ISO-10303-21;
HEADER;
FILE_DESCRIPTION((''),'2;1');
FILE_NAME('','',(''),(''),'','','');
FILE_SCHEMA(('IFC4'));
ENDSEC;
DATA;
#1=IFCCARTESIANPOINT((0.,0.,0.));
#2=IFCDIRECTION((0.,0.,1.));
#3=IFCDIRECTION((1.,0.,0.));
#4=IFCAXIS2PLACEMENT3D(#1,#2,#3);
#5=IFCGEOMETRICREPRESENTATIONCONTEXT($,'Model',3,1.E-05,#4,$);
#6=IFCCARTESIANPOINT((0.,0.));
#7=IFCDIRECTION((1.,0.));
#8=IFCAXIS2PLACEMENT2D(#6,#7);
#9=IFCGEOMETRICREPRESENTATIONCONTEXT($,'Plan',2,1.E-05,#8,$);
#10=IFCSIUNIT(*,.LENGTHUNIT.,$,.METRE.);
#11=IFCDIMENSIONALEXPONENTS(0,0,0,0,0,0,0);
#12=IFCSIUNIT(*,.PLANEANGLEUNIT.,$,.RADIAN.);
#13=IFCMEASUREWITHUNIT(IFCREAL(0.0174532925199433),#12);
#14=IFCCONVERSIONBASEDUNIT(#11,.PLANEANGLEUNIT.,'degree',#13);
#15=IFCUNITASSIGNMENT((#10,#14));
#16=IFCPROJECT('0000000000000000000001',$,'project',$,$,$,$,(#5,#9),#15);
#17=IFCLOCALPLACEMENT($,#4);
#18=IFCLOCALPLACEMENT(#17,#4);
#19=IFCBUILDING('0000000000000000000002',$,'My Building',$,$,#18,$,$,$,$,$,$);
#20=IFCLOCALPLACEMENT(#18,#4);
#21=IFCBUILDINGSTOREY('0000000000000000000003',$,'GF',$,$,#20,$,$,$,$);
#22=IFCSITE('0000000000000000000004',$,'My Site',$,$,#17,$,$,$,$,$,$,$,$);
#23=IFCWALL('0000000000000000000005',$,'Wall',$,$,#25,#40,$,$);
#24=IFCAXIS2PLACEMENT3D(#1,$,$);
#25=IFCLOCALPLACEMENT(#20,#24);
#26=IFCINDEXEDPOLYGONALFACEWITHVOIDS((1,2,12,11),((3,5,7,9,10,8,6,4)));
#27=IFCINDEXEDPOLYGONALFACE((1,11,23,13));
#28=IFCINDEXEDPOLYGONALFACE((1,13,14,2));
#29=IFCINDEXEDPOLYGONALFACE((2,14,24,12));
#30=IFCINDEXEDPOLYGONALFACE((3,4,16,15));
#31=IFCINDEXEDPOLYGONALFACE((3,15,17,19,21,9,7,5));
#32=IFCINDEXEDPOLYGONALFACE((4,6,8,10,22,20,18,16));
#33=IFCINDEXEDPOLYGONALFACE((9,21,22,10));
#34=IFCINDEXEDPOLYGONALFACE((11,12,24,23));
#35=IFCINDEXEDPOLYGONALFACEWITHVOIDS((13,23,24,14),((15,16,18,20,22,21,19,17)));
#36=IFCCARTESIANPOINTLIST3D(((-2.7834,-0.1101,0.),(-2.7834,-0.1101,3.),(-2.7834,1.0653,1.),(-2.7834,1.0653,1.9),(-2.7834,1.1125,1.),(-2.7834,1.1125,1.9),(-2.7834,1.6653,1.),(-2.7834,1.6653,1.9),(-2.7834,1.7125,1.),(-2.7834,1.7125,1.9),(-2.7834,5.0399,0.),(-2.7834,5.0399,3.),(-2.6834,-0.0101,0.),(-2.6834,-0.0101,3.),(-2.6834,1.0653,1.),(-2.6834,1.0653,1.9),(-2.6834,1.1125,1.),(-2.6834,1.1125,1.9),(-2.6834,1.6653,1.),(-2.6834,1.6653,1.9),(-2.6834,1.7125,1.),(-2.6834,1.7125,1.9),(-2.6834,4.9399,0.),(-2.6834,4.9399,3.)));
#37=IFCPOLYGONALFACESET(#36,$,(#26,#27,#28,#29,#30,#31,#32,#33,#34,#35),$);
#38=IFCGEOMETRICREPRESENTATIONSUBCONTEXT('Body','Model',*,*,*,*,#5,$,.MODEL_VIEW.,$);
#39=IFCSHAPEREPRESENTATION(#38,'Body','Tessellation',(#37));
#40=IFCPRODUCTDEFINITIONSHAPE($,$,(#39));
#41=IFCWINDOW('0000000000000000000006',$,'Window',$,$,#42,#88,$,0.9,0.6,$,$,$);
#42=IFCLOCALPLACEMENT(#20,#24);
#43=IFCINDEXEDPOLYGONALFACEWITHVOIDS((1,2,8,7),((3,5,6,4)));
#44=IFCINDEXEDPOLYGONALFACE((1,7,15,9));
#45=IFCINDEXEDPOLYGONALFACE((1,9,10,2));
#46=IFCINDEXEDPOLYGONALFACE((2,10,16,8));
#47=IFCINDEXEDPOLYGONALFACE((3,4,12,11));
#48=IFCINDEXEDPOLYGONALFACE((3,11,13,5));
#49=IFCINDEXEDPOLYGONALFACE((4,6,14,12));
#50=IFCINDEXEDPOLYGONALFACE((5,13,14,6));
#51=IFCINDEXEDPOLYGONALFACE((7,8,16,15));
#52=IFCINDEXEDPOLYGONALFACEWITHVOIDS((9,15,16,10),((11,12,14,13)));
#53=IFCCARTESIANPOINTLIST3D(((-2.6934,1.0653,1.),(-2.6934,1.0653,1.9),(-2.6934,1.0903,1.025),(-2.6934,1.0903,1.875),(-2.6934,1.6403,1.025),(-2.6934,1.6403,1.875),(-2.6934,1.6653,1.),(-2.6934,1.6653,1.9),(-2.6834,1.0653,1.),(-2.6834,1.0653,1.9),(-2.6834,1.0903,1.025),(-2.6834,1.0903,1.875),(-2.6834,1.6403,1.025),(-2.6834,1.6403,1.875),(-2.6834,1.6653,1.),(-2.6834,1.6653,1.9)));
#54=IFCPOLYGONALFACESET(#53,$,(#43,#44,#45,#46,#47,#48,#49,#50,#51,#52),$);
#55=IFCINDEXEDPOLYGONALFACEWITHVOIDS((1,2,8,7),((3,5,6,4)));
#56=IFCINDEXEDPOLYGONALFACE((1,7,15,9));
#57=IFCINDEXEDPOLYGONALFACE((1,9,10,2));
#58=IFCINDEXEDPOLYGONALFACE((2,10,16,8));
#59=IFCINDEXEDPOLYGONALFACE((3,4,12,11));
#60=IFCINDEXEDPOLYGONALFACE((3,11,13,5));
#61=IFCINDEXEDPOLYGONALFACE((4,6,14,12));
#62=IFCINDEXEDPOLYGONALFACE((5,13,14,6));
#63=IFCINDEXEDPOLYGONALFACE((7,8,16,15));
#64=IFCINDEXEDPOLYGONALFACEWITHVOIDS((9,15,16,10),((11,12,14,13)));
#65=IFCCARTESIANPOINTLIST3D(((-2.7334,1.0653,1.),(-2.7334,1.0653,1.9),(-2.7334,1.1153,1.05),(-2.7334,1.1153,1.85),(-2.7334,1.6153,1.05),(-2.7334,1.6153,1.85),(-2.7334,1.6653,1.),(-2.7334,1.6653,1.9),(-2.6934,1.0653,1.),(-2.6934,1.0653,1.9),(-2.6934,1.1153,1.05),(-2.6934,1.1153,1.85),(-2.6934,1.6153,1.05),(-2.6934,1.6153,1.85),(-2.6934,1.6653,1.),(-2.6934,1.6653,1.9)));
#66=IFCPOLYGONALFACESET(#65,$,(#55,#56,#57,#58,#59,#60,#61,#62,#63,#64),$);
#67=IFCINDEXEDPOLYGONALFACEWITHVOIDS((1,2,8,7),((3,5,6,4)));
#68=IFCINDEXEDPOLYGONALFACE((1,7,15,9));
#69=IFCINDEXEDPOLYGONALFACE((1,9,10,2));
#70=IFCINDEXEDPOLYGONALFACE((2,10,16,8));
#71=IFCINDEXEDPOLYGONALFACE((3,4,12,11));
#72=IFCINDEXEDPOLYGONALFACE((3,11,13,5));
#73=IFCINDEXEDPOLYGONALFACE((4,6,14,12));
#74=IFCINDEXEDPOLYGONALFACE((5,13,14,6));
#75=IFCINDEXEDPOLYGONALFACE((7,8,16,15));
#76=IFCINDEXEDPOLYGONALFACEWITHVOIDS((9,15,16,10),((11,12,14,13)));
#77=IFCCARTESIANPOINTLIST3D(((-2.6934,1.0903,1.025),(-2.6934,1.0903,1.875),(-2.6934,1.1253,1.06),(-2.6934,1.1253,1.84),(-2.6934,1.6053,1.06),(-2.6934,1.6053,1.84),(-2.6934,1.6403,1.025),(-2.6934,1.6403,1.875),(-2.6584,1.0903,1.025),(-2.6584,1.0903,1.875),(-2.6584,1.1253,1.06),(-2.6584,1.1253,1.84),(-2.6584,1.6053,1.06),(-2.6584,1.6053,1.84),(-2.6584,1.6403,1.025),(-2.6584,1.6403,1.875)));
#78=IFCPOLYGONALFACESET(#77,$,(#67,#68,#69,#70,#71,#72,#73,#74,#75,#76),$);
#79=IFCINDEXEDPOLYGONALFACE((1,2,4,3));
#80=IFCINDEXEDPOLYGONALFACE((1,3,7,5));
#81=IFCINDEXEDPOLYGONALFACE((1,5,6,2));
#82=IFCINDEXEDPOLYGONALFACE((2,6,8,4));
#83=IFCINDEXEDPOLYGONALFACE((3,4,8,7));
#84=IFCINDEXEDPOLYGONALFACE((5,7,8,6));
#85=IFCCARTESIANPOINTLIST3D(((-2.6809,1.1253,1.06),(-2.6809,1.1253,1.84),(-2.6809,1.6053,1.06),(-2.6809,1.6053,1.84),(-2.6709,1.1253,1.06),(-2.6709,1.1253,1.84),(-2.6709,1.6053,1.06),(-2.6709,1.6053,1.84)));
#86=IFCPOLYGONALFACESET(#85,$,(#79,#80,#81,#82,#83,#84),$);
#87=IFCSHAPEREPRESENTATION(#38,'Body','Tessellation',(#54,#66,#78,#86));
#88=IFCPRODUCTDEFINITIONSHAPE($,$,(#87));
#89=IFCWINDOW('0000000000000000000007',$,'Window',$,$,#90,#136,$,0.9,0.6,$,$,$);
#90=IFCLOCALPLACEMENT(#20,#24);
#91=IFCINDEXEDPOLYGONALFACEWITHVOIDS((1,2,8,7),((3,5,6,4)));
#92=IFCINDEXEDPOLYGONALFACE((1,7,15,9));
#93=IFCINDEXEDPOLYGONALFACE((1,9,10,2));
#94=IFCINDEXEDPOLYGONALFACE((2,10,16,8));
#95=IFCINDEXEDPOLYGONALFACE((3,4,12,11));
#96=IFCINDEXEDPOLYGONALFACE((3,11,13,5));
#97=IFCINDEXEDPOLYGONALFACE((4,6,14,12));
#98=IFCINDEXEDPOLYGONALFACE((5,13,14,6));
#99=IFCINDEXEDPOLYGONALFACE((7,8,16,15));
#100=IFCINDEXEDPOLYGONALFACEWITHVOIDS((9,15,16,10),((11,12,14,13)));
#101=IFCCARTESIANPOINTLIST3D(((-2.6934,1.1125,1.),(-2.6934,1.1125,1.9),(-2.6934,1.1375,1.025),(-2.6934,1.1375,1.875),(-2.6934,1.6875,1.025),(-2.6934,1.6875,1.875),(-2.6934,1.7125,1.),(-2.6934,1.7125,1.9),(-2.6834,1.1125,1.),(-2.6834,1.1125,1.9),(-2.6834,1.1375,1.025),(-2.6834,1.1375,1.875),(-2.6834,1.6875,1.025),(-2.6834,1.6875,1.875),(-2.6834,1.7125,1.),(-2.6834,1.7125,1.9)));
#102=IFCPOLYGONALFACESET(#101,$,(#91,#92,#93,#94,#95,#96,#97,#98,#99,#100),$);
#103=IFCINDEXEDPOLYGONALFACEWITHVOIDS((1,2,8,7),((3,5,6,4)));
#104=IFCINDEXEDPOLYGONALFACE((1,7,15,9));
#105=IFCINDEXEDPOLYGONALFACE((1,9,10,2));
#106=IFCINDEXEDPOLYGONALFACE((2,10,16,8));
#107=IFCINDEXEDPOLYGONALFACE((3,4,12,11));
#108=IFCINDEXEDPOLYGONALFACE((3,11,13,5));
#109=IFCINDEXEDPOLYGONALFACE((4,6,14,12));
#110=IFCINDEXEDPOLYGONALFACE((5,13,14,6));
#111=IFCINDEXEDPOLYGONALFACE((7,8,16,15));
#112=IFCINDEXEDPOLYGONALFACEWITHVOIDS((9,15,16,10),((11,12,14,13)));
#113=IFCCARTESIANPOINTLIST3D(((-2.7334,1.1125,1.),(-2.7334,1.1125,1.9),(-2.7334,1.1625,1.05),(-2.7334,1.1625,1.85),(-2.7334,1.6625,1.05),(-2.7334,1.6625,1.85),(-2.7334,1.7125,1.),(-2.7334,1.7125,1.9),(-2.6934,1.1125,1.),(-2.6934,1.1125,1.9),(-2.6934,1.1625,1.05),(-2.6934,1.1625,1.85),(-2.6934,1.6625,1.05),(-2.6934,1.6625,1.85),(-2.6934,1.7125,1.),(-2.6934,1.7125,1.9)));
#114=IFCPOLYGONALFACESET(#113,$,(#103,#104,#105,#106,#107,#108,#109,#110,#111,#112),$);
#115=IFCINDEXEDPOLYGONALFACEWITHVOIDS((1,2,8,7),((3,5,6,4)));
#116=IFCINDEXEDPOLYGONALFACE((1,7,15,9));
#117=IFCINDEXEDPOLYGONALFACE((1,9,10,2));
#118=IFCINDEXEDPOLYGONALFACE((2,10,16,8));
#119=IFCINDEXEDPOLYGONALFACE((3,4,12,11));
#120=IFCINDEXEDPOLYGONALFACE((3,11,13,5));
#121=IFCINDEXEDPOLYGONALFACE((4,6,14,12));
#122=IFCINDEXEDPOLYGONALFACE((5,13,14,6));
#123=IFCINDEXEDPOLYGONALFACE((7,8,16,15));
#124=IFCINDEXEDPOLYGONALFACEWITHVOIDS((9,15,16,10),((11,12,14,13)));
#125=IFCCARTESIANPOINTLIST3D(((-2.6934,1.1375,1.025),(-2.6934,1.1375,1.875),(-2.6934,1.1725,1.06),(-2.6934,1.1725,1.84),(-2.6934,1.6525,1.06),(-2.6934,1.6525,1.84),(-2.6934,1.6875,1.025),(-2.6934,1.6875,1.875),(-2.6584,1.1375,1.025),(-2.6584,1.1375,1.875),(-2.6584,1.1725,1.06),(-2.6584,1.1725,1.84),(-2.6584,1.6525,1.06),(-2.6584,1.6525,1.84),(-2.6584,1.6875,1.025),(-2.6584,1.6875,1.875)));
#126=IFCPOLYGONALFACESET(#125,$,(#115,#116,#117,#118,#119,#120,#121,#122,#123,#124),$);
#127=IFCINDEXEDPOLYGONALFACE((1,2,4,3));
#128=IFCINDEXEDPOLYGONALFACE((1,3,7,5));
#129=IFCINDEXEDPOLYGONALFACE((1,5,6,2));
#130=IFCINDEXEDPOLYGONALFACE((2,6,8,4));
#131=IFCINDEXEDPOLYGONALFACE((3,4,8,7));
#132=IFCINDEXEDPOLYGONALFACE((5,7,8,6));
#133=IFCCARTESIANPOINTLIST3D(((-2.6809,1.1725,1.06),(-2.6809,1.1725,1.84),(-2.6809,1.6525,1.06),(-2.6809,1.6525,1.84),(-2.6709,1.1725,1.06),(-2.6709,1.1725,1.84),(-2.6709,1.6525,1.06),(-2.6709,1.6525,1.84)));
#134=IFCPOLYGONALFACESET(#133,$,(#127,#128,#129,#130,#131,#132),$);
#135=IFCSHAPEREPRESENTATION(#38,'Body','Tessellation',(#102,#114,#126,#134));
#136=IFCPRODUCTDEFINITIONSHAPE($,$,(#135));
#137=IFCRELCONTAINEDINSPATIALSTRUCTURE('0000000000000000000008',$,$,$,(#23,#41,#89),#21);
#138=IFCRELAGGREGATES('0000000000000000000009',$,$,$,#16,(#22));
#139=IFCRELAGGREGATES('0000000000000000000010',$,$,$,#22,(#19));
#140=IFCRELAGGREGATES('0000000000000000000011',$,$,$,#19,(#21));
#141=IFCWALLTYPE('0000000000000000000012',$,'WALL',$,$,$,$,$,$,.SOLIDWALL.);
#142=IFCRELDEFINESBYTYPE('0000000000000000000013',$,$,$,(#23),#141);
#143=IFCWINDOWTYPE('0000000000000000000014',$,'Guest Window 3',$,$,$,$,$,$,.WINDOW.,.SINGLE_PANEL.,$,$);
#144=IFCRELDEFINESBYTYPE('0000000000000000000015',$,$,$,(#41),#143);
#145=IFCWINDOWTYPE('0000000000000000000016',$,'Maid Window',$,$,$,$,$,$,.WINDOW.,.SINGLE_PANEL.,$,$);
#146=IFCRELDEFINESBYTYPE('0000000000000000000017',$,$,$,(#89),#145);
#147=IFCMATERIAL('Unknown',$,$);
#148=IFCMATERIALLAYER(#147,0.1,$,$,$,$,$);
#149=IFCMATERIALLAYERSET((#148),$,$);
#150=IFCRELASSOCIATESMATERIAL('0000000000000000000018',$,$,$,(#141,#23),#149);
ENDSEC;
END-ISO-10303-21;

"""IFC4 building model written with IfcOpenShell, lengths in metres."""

from ifc_helpers import new_model, entity, si_unit, converted_unit, frame, origin_with_axes, origin_2d_with_axis, place, context, subcontext, project, spatial, line, indexed_curve, outline, extrude, shape, source, transform, mapped, material, layer, layer_set, layer_usage, type_object, type_shapes, element, fill, save


model = new_model("IFC4")

# Units and contexts
model_context = context("Model", 3, precision=1e-05, world=origin_with_axes())
plan_context = context("Plan", 2, precision=1e-05, world=origin_2d_with_axis())
body_context_1 = subcontext(model_context, "Body", "Model", "MODEL_VIEW")
body_context_2 = subcontext(plan_context, "Body", "Plan", "PLAN_VIEW")
ifc_project = project(units=[si_unit("LENGTHUNIT", "METRE"), converted_unit("PLANEANGLEUNIT", "degree", entity("IfcReal", 0.0174532925199433), si_unit("PLANEANGLEUNIT", "RADIAN"), dimensions=[0, 0, 0, 0, 0, 0, 0])], contexts=[model_context, plan_context])

# Site, building, storey
site_placement = place(None, origin_with_axes())
site = spatial("IfcSite", under=ifc_project, at=site_placement, Name="My Site")
building_placement = place(site_placement, origin_with_axes())
building = spatial("IfcBuilding", under=site, at=building_placement, Name="My Building")
storey_placement = place(building_placement, origin_with_axes())
storey = spatial("IfcBuildingStorey", under=building, at=storey_placement, Name="GF")

# Shared definitions
ifc_material = material(Name="Unknown")

# Shared definitions
ifc_layer = layer(ifc_material, 0.1)
ifc_layer_set = layer_set([ifc_layer])
wall_type = type_object("IfcWallType", Name="WALL", PredefinedType="SOLIDWALL", material=ifc_layer_set)

# Wall, openings, windows
shared_shape_1 = source(origin_with_axes(), body_context_1, "Body", "SweptSolid", [
    extrude(outline(indexed_curve([(0.0, 0.0), (0.6, 0.0), (0.6, 0.9), (0.0, 0.9)], segments=[line(1, 2, 3, 4, 1)])), frame((0.0, -0.6, 0.0), z_axis=(0.0, -1.0, 0.0), x_axis=(1.0, 0.0, 0.0)), (0.0, 0.0, -1.0), 1.2),
])
window_type_1 = type_object("IfcWindowType", Name="Maid Window", PartitioningType="SINGLE_PANEL", PredefinedType="WINDOW")
shared_shape_2 = source(origin_with_axes(), body_context_1, "Body", "SweptSolid", [
    extrude(outline(indexed_curve([(0.0, 0.0), (0.6, 0.0), (0.6, 0.9), (0.0, 0.9)], segments=[line(1, 2, 3, 4, 1)]), holes=[indexed_curve([(0.025, 0.025), (0.575, 0.025), (0.575, 0.875), (0.025, 0.875)], segments=[line(1, 2, 3, 4, 1)])]), frame((0.0, 0.09, 0.0), z_axis=(0.0, -1.0, 0.0), x_axis=(1.0, 0.0, 0.0)), (0.0, 0.0, -1.0), 0.01),
    extrude(outline(indexed_curve([(0.0, 0.0), (0.6, 0.0), (0.6, 0.9), (0.0, 0.9)], segments=[line(1, 2, 3, 4, 1)]), holes=[indexed_curve([(0.05, 0.05), (0.55, 0.05), (0.55, 0.85), (0.05, 0.85)], segments=[line(1, 2, 3, 4, 1)])]), frame((0.0, 0.05, 0.0), z_axis=(0.0, -1.0, 0.0), x_axis=(1.0, 0.0, 0.0)), (0.0, 0.0, -1.0), 0.04),
    extrude(outline(indexed_curve([(0.0, 0.0), (0.55, 0.0), (0.55, 0.85), (0.0, 0.85)], segments=[line(1, 2, 3, 4, 1)]), holes=[indexed_curve([(0.035, 0.035), (0.515, 0.035), (0.515, 0.815), (0.035, 0.815)], segments=[line(1, 2, 3, 4, 1)])]), frame((0.025, 0.09, 0.025), z_axis=(0.0, -1.0, 0.0), x_axis=(1.0, 0.0, 0.0)), (0.0, 0.0, -1.0), 0.035),
    extrude(outline(indexed_curve([(0.035, 0.035), (0.515, 0.035), (0.515, 0.815), (0.035, 0.815)], segments=[line(1, 2, 3, 4, 1)])), frame((0.025, 0.1025, 0.025), z_axis=(0.0, -1.0, 0.0), x_axis=(1.0, 0.0, 0.0)), (0.0, 0.0, -1.0), 0.01),
])
shared_shape_3 = source(origin_with_axes(), body_context_2, "Body", "Curve2D", [
    entity("IfcIndexedPolyCurve", entity("IfcCartesianPointList2D", [[0.05, 0.05], [0.55, 0.05]])),
    entity("IfcIndexedPolyCurve", entity("IfcCartesianPointList2D", [[0.0, 0.1], [0.025, 0.1], [0.025, 0.09], [0.05, 0.09], [0.05, 0.05], [0.0, 0.05]]), [entity("IfcLineIndex", [1, 2, 3, 4, 5, 6, 1])]),
    entity("IfcIndexedPolyCurve", entity("IfcCartesianPointList2D", [[0.6, 0.1], [0.575, 0.1], [0.575, 0.09], [0.55, 0.09], [0.55, 0.05], [0.6, 0.05]]), [entity("IfcLineIndex", [1, 2, 3, 4, 5, 6, 1])]),
    entity("IfcIndexedPolyCurve", entity("IfcCartesianPointList2D", [[0.025, 0.09], [0.06, 0.09], [0.06, 0.125], [0.025, 0.125]]), [entity("IfcLineIndex", [1, 2, 3, 4, 1])]),
    entity("IfcIndexedPolyCurve", entity("IfcCartesianPointList2D", [[0.575, 0.09], [0.54, 0.09], [0.54, 0.125], [0.575, 0.125]]), [entity("IfcLineIndex", [1, 2, 3, 4, 1])]),
    entity("IfcIndexedPolyCurve", entity("IfcCartesianPointList2D", [[0.06, 0.09], [0.54, 0.09]])),
    entity("IfcIndexedPolyCurve", entity("IfcCartesianPointList2D", [[0.06, 0.125], [0.54, 0.125]])),
    entity("IfcIndexedPolyCurve", entity("IfcCartesianPointList2D", [[0.06, 0.1075], [0.54, 0.1075]])),
])
type_shapes(window_type_1, [shared_shape_2, shared_shape_3])
ifc_layer_usage_1 = layer_usage(ifc_layer_set, "AXIS2", "POSITIVE", 0.0)
wall_1_placement = place(storey_placement, frame((-2.7834, 5.0399, 0.0), z_axis=(0.0, 0.0, 1.0), x_axis=(0.0, -1.0, 0.0)))
wall_1 = element("IfcWall", 1, at=wall_1_placement, inside=storey, type_object=wall_type, material=ifc_layer_usage_1, Name="Wall", context=body_context_1, shape_type="SweptSolid", body=[
    extrude(outline(indexed_curve([(0.0, 0.0), (0.1, 0.1), (5.05, 0.1), (5.15, 0.0)], segments=[line(1, 2, 3, 4, 1)])), origin_with_axes(), (0.0, 0.0, 1.0), 3.0),
])
opening_1_placement = place(wall_1_placement, frame((3.3274, 0.0, 1.0), z_axis=(0.0, 0.0, 1.0), x_axis=(1.0, 0.0, 0.0)))
opening_1 = element("IfcOpeningElement", 2, at=opening_1_placement, cuts=wall_1, PredefinedType="OPENING", context=body_context_1, shape_type="MappedRepresentation", body=[
    mapped(shared_shape_1, transform((0.0, 0.0, 0.0), x_axis=(1.0, 0.0, 0.0), y_axis=(0.0, 1.0, 0.0), z_axis=(0.0, 0.0, 1.0), scale=1.0)),
])
shared_shape_4 = source(origin_with_axes(), body_context_1, "Body", "SweptSolid", [
    extrude(outline(indexed_curve([(0.0, 0.0), (0.6, 0.0), (0.6, 0.9), (0.0, 0.9)], segments=[line(1, 2, 3, 4, 1)])), frame((0.0, -0.6, 0.0), z_axis=(0.0, -1.0, 0.0), x_axis=(1.0, 0.0, 0.0)), (0.0, 0.0, -1.0), 1.2),
])
opening_2_placement = place(wall_1_placement, frame((3.3746, 0.0, 1.0), z_axis=(0.0, 0.0, 1.0), x_axis=(1.0, 0.0, 0.0)))
opening_2 = element("IfcOpeningElement", 3, at=opening_2_placement, cuts=wall_1, PredefinedType="OPENING", context=body_context_1, shape_type="MappedRepresentation", body=[
    mapped(shared_shape_4, transform((0.0, 0.0, 0.0), x_axis=(1.0, 0.0, 0.0), y_axis=(0.0, 1.0, 0.0), z_axis=(0.0, 0.0, 1.0), scale=1.0)),
])
window_type_2 = type_object("IfcWindowType", Name="Guest Window 3", PartitioningType="SINGLE_PANEL", PredefinedType="WINDOW")
shared_shape_5 = source(origin_with_axes(), body_context_1, "Body", "SweptSolid", [
    extrude(outline(indexed_curve([(0.0, 0.0), (0.6, 0.0), (0.6, 0.9), (0.0, 0.9)], segments=[line(1, 2, 3, 4, 1)]), holes=[indexed_curve([(0.025, 0.025), (0.575, 0.025), (0.575, 0.875), (0.025, 0.875)], segments=[line(1, 2, 3, 4, 1)])]), frame((0.0, 0.09, 0.0), z_axis=(0.0, -1.0, 0.0), x_axis=(1.0, 0.0, 0.0)), (0.0, 0.0, -1.0), 0.01),
    extrude(outline(indexed_curve([(0.0, 0.0), (0.6, 0.0), (0.6, 0.9), (0.0, 0.9)], segments=[line(1, 2, 3, 4, 1)]), holes=[indexed_curve([(0.05, 0.05), (0.55, 0.05), (0.55, 0.85), (0.05, 0.85)], segments=[line(1, 2, 3, 4, 1)])]), frame((0.0, 0.05, 0.0), z_axis=(0.0, -1.0, 0.0), x_axis=(1.0, 0.0, 0.0)), (0.0, 0.0, -1.0), 0.04),
    extrude(outline(indexed_curve([(0.0, 0.0), (0.55, 0.0), (0.55, 0.85), (0.0, 0.85)], segments=[line(1, 2, 3, 4, 1)]), holes=[indexed_curve([(0.035, 0.035), (0.515, 0.035), (0.515, 0.815), (0.035, 0.815)], segments=[line(1, 2, 3, 4, 1)])]), frame((0.025, 0.09, 0.025), z_axis=(0.0, -1.0, 0.0), x_axis=(1.0, 0.0, 0.0)), (0.0, 0.0, -1.0), 0.035),
    extrude(outline(indexed_curve([(0.035, 0.035), (0.515, 0.035), (0.515, 0.815), (0.035, 0.815)], segments=[line(1, 2, 3, 4, 1)])), frame((0.025, 0.1025, 0.025), z_axis=(0.0, -1.0, 0.0), x_axis=(1.0, 0.0, 0.0)), (0.0, 0.0, -1.0), 0.01),
])
shared_shape_6 = source(origin_with_axes(), body_context_2, "Body", "Curve2D", [
    entity("IfcIndexedPolyCurve", entity("IfcCartesianPointList2D", [[0.05, 0.05], [0.55, 0.05]])),
    entity("IfcIndexedPolyCurve", entity("IfcCartesianPointList2D", [[0.0, 0.1], [0.025, 0.1], [0.025, 0.09], [0.05, 0.09], [0.05, 0.05], [0.0, 0.05]]), [entity("IfcLineIndex", [1, 2, 3, 4, 5, 6, 1])]),
    entity("IfcIndexedPolyCurve", entity("IfcCartesianPointList2D", [[0.6, 0.1], [0.575, 0.1], [0.575, 0.09], [0.55, 0.09], [0.55, 0.05], [0.6, 0.05]]), [entity("IfcLineIndex", [1, 2, 3, 4, 5, 6, 1])]),
    entity("IfcIndexedPolyCurve", entity("IfcCartesianPointList2D", [[0.025, 0.09], [0.06, 0.09], [0.06, 0.125], [0.025, 0.125]]), [entity("IfcLineIndex", [1, 2, 3, 4, 1])]),
    entity("IfcIndexedPolyCurve", entity("IfcCartesianPointList2D", [[0.575, 0.09], [0.54, 0.09], [0.54, 0.125], [0.575, 0.125]]), [entity("IfcLineIndex", [1, 2, 3, 4, 1])]),
    entity("IfcIndexedPolyCurve", entity("IfcCartesianPointList2D", [[0.06, 0.09], [0.54, 0.09]])),
    entity("IfcIndexedPolyCurve", entity("IfcCartesianPointList2D", [[0.06, 0.125], [0.54, 0.125]])),
    entity("IfcIndexedPolyCurve", entity("IfcCartesianPointList2D", [[0.06, 0.1075], [0.54, 0.1075]])),
])
type_shapes(window_type_2, [shared_shape_5, shared_shape_6])
window_1_placement = place(opening_2_placement, frame((0.0, 0.0, 0.0), z_axis=(0.0, 0.0, 1.0), x_axis=(1.0, 0.0, 0.0)))
window_1 = element("IfcWindow", 4, at=window_1_placement, inside=storey, type_object=window_type_2, Name="Window", OverallHeight=0.9, OverallWidth=0.6, shapes=[
    shape(body_context_1, "Body", "MappedRepresentation", [mapped(shared_shape_5, transform((0.0, 0.0, 0.0), x_axis=(1.0, 0.0, 0.0), y_axis=(0.0, 1.0, 0.0), z_axis=(0.0, 0.0, 1.0), scale=1.0))]),
    shape(body_context_2, "Body", "MappedRepresentation", [mapped(shared_shape_6, transform((0.0, 0.0, 0.0), x_axis=(1.0, 0.0, 0.0), y_axis=(0.0, 1.0, 0.0), z_axis=(0.0, 0.0, 1.0), scale=1.0))]),
])
fill(opening_2, window_1)
window_2_placement = place(opening_1_placement, frame((0.0, 0.0, 0.0), z_axis=(0.0, 0.0, 1.0), x_axis=(1.0, 0.0, 0.0)))
window_2 = element("IfcWindow", 5, at=window_2_placement, inside=storey, type_object=window_type_1, Name="Window", OverallHeight=0.9, OverallWidth=0.6, shapes=[
    shape(body_context_1, "Body", "MappedRepresentation", [mapped(shared_shape_2, transform((0.0, 0.0, 0.0), x_axis=(1.0, 0.0, 0.0), y_axis=(0.0, 1.0, 0.0), z_axis=(0.0, 0.0, 1.0), scale=1.0))]),
    shape(body_context_2, "Body", "MappedRepresentation", [mapped(shared_shape_3, transform((0.0, 0.0, 0.0), x_axis=(1.0, 0.0, 0.0), y_axis=(0.0, 1.0, 0.0), z_axis=(0.0, 0.0, 1.0), scale=1.0))]),
])
fill(opening_1, window_2)

save(model, "model.ifc")
